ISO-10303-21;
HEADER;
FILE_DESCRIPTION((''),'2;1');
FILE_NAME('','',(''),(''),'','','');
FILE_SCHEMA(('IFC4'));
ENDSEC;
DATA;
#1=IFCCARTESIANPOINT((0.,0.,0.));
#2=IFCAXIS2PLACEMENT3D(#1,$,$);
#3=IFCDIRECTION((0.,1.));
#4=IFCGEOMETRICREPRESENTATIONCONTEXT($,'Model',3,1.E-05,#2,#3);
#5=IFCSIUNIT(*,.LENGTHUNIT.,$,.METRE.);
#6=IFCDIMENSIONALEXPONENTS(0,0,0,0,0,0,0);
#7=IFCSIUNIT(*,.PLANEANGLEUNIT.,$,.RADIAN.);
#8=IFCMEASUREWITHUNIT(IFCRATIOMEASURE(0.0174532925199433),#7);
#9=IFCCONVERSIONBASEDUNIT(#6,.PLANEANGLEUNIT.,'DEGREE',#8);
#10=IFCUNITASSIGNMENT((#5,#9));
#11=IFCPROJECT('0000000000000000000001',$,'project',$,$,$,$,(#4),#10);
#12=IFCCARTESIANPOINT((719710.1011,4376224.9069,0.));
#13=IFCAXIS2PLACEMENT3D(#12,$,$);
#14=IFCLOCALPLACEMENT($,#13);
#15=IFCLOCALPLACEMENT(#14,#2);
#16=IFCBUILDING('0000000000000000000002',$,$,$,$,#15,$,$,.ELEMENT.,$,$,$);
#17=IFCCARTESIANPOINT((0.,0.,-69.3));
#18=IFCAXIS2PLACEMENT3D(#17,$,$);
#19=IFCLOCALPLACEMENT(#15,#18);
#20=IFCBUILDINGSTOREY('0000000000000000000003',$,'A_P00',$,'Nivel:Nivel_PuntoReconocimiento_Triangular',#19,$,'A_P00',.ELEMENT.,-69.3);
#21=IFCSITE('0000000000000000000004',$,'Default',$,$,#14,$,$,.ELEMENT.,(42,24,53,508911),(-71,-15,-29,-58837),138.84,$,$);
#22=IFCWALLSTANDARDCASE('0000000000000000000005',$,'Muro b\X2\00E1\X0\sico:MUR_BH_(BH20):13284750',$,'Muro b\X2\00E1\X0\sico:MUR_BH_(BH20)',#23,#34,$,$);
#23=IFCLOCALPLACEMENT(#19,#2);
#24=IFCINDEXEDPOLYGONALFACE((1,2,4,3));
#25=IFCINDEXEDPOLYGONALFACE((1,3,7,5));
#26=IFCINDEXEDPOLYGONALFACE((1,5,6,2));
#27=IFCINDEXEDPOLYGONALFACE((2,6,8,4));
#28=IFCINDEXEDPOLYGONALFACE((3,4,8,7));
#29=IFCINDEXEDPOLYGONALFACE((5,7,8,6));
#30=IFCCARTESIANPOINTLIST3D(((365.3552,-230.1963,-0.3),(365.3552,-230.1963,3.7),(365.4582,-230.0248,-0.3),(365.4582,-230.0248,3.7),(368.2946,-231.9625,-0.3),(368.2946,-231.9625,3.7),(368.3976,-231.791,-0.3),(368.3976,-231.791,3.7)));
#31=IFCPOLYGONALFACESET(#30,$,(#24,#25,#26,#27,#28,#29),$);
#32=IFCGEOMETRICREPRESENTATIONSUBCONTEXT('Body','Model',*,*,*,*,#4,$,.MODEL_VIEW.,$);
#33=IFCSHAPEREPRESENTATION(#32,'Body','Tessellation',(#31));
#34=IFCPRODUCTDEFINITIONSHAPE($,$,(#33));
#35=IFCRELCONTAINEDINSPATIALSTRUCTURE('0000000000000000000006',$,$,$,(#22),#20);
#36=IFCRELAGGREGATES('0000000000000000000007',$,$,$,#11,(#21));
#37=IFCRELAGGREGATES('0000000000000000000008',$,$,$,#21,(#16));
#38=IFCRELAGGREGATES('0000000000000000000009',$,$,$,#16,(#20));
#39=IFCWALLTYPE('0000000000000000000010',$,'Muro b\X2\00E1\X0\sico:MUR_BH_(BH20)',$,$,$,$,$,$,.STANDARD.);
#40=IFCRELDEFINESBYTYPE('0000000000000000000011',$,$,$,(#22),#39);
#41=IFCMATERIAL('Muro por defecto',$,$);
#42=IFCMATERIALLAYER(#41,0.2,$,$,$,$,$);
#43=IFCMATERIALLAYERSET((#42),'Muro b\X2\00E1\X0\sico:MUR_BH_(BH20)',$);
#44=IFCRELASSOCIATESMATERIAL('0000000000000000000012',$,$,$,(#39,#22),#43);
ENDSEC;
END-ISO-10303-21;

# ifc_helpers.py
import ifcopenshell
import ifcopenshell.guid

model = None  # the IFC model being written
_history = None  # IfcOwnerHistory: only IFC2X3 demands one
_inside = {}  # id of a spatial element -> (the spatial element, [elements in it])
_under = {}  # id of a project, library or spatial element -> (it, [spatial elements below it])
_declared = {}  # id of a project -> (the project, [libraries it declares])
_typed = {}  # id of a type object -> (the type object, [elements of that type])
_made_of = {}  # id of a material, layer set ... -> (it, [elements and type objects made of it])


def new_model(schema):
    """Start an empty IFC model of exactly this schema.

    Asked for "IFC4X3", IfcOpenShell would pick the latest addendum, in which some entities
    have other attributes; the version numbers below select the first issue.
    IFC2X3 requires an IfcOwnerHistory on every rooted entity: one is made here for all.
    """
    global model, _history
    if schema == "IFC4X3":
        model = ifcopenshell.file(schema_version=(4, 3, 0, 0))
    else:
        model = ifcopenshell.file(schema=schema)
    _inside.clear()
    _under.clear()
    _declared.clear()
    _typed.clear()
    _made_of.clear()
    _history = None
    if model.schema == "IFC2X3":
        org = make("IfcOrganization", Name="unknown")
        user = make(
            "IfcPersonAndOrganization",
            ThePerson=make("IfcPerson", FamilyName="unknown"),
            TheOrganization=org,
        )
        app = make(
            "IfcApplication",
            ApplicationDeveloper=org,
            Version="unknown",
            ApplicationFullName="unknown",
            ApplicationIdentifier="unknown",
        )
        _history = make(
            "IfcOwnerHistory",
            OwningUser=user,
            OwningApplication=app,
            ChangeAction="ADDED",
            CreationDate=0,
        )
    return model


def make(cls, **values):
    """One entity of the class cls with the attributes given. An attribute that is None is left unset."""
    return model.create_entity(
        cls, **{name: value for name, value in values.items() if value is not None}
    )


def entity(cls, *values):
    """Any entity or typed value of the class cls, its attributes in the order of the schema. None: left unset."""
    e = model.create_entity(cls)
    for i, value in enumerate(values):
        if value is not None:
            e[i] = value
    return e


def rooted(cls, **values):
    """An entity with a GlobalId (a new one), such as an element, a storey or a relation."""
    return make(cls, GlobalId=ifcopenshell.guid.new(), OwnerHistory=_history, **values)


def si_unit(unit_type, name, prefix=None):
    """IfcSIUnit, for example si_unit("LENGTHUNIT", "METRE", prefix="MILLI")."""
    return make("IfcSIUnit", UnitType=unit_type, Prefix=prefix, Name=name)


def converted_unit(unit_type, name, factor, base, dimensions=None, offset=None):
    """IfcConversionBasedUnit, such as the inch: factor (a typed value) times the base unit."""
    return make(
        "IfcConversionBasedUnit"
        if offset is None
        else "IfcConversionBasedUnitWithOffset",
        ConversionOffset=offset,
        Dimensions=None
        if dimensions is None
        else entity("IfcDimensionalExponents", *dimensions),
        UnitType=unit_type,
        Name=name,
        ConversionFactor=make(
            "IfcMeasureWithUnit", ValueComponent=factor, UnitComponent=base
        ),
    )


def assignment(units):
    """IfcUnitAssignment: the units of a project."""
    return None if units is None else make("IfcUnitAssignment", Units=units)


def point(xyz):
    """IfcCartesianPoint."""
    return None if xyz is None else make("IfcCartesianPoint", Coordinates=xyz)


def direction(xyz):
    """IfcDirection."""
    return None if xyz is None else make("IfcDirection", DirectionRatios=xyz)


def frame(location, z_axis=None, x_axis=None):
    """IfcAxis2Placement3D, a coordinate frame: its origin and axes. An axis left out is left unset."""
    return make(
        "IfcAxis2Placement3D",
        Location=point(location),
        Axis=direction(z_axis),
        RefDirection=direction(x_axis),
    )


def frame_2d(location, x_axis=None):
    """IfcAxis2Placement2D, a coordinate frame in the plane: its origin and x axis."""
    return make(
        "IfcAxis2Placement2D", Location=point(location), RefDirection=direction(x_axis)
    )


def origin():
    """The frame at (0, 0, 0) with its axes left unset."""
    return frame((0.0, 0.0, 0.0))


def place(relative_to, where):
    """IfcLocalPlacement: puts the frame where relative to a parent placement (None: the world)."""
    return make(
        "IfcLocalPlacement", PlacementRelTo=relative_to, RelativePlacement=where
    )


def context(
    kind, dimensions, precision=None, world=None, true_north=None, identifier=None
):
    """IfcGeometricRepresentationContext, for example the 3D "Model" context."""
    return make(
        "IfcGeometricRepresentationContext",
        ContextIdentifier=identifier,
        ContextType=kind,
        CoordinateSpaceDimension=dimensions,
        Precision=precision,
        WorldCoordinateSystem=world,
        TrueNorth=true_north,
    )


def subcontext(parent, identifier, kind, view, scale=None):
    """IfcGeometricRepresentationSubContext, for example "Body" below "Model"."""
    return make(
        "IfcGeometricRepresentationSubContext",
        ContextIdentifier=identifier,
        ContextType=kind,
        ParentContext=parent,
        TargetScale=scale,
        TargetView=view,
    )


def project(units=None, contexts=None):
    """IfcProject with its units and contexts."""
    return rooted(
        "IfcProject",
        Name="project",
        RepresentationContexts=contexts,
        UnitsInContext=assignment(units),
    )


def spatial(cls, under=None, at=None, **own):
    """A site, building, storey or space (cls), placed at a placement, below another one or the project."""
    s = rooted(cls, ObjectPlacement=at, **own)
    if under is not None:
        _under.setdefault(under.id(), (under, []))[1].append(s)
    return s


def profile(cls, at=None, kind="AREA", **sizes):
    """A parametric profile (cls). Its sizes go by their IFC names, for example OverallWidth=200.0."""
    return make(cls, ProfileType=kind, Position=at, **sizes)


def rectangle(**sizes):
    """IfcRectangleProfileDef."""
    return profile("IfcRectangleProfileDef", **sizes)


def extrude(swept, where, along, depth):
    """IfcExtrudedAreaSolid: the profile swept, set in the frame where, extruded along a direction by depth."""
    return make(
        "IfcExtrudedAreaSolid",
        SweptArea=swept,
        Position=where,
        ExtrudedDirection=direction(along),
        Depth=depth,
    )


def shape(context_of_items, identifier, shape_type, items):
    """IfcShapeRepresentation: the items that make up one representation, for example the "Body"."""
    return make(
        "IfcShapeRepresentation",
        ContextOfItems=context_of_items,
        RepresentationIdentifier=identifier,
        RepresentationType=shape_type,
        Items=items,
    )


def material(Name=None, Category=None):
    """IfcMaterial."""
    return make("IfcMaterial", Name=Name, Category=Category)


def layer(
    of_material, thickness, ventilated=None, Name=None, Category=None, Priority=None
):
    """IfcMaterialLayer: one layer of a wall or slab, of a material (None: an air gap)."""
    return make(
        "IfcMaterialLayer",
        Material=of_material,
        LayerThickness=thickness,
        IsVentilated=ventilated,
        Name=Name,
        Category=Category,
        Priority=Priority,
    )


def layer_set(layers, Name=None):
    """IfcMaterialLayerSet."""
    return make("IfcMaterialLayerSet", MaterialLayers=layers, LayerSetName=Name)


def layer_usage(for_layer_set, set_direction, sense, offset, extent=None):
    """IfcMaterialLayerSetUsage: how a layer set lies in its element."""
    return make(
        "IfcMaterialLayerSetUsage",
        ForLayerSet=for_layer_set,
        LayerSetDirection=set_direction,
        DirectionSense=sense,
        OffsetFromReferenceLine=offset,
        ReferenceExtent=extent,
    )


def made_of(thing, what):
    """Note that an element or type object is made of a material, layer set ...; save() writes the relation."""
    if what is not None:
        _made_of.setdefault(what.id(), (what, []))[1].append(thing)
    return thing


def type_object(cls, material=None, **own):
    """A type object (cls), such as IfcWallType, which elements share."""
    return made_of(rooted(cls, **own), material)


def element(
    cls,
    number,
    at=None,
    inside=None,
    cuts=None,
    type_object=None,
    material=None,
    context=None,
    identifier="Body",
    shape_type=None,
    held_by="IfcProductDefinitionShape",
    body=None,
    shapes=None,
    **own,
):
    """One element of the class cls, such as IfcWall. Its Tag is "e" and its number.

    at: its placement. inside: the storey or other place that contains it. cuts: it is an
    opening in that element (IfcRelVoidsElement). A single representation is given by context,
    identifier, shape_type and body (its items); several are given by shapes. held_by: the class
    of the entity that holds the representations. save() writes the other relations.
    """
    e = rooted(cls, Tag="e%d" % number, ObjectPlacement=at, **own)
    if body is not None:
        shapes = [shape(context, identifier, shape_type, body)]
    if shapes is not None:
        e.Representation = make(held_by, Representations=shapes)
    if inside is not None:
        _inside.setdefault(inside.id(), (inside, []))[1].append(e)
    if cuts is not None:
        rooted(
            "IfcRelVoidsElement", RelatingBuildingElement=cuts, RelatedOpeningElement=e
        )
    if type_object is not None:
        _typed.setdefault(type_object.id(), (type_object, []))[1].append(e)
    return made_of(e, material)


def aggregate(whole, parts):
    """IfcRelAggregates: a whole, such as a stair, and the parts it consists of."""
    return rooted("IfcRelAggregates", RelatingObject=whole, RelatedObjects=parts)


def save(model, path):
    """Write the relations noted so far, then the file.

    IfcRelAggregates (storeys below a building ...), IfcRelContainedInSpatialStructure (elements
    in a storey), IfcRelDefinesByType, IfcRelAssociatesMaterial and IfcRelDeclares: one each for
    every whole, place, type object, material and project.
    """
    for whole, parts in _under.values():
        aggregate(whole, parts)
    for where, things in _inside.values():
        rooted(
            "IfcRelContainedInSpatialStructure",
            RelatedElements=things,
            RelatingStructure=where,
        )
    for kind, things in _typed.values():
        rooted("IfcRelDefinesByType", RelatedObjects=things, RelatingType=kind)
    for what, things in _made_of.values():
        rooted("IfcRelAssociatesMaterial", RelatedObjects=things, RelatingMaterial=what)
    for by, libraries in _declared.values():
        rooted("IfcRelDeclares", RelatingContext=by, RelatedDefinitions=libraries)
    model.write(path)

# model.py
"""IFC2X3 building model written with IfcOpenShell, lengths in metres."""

from ifc_helpers import new_model, entity, si_unit, converted_unit, direction, frame, frame_2d, origin, place, context, subcontext, project, spatial, rectangle, extrude, material, layer, layer_set, layer_usage, type_object, element, save


model = new_model("IFC2X3")

# Units and contexts
model_context = context("Model", 3, precision=1e-05, world=origin(), true_north=direction((0.0, 1.0)))
body_context = subcontext(model_context, "Body", "Model", "MODEL_VIEW")
ifc_project = project(units=[si_unit("LENGTHUNIT", "METRE"), converted_unit("PLANEANGLEUNIT", "DEGREE", entity("IfcRatioMeasure", 0.0174532925199433), si_unit("PLANEANGLEUNIT", "RADIAN"), dimensions=[0, 0, 0, 0, 0, 0, 0])], contexts=[model_context])

# Site, building, storey
site_placement = place(None, frame((719710.1011, 4376224.9069, 0.0)))
site = spatial("IfcSite", under=ifc_project, at=site_placement, Name="Default", CompositionType="ELEMENT", RefLatitude=(42, 24, 53, 508911), RefLongitude=(-71, -15, -29, -58837), RefElevation=138.84)
building_placement = place(site_placement, origin())
building = spatial("IfcBuilding", under=site, at=building_placement, CompositionType="ELEMENT")
storey_placement = place(building_placement, frame((0.0, 0.0, -69.3)))
storey = spatial("IfcBuildingStorey", under=building, at=storey_placement, Name="A_P00", ObjectType="Nivel:Nivel_PuntoReconocimiento_Triangular", LongName="A_P00", CompositionType="ELEMENT", Elevation=-69.3)

# Shared definitions
ifc_material_1 = material(Name="Muro por defecto")
ifc_layer = layer(ifc_material_1, 0.2)
ifc_layer_set = layer_set([ifc_layer], Name="Muro básico:MUR_BH_(BH20)")
wall_type = type_object("IfcWallType", Name="Muro básico:MUR_BH_(BH20)", PredefinedType="STANDARD", material=ifc_layer_set)

# Wall
ifc_layer_usage_1 = layer_usage(ifc_layer_set, "AXIS2", "NEGATIVE", 0.1)
wall_1_placement = place(storey_placement, frame((368.3461, -231.8767, -0.3), z_axis=(0.0, 0.0, 1.0), x_axis=(-0.857167, 0.515038, 0.0)))
element("IfcWallStandardCase", 1, at=wall_1_placement, inside=storey, type_object=wall_type, material=ifc_layer_usage_1, Name="Muro básico:MUR_BH_(BH20):13284750", ObjectType="Muro básico:MUR_BH_(BH20)", context=body_context, shape_type="SweptSolid", body=[
    extrude(rectangle(XDim=3.4292, YDim=0.2, at=frame_2d((1.7146, 0.0), x_axis=(-1.0, 0.0))), origin(), (0.0, 0.0, 1.0), 4.0),
])

save(model, "model.ifc")
